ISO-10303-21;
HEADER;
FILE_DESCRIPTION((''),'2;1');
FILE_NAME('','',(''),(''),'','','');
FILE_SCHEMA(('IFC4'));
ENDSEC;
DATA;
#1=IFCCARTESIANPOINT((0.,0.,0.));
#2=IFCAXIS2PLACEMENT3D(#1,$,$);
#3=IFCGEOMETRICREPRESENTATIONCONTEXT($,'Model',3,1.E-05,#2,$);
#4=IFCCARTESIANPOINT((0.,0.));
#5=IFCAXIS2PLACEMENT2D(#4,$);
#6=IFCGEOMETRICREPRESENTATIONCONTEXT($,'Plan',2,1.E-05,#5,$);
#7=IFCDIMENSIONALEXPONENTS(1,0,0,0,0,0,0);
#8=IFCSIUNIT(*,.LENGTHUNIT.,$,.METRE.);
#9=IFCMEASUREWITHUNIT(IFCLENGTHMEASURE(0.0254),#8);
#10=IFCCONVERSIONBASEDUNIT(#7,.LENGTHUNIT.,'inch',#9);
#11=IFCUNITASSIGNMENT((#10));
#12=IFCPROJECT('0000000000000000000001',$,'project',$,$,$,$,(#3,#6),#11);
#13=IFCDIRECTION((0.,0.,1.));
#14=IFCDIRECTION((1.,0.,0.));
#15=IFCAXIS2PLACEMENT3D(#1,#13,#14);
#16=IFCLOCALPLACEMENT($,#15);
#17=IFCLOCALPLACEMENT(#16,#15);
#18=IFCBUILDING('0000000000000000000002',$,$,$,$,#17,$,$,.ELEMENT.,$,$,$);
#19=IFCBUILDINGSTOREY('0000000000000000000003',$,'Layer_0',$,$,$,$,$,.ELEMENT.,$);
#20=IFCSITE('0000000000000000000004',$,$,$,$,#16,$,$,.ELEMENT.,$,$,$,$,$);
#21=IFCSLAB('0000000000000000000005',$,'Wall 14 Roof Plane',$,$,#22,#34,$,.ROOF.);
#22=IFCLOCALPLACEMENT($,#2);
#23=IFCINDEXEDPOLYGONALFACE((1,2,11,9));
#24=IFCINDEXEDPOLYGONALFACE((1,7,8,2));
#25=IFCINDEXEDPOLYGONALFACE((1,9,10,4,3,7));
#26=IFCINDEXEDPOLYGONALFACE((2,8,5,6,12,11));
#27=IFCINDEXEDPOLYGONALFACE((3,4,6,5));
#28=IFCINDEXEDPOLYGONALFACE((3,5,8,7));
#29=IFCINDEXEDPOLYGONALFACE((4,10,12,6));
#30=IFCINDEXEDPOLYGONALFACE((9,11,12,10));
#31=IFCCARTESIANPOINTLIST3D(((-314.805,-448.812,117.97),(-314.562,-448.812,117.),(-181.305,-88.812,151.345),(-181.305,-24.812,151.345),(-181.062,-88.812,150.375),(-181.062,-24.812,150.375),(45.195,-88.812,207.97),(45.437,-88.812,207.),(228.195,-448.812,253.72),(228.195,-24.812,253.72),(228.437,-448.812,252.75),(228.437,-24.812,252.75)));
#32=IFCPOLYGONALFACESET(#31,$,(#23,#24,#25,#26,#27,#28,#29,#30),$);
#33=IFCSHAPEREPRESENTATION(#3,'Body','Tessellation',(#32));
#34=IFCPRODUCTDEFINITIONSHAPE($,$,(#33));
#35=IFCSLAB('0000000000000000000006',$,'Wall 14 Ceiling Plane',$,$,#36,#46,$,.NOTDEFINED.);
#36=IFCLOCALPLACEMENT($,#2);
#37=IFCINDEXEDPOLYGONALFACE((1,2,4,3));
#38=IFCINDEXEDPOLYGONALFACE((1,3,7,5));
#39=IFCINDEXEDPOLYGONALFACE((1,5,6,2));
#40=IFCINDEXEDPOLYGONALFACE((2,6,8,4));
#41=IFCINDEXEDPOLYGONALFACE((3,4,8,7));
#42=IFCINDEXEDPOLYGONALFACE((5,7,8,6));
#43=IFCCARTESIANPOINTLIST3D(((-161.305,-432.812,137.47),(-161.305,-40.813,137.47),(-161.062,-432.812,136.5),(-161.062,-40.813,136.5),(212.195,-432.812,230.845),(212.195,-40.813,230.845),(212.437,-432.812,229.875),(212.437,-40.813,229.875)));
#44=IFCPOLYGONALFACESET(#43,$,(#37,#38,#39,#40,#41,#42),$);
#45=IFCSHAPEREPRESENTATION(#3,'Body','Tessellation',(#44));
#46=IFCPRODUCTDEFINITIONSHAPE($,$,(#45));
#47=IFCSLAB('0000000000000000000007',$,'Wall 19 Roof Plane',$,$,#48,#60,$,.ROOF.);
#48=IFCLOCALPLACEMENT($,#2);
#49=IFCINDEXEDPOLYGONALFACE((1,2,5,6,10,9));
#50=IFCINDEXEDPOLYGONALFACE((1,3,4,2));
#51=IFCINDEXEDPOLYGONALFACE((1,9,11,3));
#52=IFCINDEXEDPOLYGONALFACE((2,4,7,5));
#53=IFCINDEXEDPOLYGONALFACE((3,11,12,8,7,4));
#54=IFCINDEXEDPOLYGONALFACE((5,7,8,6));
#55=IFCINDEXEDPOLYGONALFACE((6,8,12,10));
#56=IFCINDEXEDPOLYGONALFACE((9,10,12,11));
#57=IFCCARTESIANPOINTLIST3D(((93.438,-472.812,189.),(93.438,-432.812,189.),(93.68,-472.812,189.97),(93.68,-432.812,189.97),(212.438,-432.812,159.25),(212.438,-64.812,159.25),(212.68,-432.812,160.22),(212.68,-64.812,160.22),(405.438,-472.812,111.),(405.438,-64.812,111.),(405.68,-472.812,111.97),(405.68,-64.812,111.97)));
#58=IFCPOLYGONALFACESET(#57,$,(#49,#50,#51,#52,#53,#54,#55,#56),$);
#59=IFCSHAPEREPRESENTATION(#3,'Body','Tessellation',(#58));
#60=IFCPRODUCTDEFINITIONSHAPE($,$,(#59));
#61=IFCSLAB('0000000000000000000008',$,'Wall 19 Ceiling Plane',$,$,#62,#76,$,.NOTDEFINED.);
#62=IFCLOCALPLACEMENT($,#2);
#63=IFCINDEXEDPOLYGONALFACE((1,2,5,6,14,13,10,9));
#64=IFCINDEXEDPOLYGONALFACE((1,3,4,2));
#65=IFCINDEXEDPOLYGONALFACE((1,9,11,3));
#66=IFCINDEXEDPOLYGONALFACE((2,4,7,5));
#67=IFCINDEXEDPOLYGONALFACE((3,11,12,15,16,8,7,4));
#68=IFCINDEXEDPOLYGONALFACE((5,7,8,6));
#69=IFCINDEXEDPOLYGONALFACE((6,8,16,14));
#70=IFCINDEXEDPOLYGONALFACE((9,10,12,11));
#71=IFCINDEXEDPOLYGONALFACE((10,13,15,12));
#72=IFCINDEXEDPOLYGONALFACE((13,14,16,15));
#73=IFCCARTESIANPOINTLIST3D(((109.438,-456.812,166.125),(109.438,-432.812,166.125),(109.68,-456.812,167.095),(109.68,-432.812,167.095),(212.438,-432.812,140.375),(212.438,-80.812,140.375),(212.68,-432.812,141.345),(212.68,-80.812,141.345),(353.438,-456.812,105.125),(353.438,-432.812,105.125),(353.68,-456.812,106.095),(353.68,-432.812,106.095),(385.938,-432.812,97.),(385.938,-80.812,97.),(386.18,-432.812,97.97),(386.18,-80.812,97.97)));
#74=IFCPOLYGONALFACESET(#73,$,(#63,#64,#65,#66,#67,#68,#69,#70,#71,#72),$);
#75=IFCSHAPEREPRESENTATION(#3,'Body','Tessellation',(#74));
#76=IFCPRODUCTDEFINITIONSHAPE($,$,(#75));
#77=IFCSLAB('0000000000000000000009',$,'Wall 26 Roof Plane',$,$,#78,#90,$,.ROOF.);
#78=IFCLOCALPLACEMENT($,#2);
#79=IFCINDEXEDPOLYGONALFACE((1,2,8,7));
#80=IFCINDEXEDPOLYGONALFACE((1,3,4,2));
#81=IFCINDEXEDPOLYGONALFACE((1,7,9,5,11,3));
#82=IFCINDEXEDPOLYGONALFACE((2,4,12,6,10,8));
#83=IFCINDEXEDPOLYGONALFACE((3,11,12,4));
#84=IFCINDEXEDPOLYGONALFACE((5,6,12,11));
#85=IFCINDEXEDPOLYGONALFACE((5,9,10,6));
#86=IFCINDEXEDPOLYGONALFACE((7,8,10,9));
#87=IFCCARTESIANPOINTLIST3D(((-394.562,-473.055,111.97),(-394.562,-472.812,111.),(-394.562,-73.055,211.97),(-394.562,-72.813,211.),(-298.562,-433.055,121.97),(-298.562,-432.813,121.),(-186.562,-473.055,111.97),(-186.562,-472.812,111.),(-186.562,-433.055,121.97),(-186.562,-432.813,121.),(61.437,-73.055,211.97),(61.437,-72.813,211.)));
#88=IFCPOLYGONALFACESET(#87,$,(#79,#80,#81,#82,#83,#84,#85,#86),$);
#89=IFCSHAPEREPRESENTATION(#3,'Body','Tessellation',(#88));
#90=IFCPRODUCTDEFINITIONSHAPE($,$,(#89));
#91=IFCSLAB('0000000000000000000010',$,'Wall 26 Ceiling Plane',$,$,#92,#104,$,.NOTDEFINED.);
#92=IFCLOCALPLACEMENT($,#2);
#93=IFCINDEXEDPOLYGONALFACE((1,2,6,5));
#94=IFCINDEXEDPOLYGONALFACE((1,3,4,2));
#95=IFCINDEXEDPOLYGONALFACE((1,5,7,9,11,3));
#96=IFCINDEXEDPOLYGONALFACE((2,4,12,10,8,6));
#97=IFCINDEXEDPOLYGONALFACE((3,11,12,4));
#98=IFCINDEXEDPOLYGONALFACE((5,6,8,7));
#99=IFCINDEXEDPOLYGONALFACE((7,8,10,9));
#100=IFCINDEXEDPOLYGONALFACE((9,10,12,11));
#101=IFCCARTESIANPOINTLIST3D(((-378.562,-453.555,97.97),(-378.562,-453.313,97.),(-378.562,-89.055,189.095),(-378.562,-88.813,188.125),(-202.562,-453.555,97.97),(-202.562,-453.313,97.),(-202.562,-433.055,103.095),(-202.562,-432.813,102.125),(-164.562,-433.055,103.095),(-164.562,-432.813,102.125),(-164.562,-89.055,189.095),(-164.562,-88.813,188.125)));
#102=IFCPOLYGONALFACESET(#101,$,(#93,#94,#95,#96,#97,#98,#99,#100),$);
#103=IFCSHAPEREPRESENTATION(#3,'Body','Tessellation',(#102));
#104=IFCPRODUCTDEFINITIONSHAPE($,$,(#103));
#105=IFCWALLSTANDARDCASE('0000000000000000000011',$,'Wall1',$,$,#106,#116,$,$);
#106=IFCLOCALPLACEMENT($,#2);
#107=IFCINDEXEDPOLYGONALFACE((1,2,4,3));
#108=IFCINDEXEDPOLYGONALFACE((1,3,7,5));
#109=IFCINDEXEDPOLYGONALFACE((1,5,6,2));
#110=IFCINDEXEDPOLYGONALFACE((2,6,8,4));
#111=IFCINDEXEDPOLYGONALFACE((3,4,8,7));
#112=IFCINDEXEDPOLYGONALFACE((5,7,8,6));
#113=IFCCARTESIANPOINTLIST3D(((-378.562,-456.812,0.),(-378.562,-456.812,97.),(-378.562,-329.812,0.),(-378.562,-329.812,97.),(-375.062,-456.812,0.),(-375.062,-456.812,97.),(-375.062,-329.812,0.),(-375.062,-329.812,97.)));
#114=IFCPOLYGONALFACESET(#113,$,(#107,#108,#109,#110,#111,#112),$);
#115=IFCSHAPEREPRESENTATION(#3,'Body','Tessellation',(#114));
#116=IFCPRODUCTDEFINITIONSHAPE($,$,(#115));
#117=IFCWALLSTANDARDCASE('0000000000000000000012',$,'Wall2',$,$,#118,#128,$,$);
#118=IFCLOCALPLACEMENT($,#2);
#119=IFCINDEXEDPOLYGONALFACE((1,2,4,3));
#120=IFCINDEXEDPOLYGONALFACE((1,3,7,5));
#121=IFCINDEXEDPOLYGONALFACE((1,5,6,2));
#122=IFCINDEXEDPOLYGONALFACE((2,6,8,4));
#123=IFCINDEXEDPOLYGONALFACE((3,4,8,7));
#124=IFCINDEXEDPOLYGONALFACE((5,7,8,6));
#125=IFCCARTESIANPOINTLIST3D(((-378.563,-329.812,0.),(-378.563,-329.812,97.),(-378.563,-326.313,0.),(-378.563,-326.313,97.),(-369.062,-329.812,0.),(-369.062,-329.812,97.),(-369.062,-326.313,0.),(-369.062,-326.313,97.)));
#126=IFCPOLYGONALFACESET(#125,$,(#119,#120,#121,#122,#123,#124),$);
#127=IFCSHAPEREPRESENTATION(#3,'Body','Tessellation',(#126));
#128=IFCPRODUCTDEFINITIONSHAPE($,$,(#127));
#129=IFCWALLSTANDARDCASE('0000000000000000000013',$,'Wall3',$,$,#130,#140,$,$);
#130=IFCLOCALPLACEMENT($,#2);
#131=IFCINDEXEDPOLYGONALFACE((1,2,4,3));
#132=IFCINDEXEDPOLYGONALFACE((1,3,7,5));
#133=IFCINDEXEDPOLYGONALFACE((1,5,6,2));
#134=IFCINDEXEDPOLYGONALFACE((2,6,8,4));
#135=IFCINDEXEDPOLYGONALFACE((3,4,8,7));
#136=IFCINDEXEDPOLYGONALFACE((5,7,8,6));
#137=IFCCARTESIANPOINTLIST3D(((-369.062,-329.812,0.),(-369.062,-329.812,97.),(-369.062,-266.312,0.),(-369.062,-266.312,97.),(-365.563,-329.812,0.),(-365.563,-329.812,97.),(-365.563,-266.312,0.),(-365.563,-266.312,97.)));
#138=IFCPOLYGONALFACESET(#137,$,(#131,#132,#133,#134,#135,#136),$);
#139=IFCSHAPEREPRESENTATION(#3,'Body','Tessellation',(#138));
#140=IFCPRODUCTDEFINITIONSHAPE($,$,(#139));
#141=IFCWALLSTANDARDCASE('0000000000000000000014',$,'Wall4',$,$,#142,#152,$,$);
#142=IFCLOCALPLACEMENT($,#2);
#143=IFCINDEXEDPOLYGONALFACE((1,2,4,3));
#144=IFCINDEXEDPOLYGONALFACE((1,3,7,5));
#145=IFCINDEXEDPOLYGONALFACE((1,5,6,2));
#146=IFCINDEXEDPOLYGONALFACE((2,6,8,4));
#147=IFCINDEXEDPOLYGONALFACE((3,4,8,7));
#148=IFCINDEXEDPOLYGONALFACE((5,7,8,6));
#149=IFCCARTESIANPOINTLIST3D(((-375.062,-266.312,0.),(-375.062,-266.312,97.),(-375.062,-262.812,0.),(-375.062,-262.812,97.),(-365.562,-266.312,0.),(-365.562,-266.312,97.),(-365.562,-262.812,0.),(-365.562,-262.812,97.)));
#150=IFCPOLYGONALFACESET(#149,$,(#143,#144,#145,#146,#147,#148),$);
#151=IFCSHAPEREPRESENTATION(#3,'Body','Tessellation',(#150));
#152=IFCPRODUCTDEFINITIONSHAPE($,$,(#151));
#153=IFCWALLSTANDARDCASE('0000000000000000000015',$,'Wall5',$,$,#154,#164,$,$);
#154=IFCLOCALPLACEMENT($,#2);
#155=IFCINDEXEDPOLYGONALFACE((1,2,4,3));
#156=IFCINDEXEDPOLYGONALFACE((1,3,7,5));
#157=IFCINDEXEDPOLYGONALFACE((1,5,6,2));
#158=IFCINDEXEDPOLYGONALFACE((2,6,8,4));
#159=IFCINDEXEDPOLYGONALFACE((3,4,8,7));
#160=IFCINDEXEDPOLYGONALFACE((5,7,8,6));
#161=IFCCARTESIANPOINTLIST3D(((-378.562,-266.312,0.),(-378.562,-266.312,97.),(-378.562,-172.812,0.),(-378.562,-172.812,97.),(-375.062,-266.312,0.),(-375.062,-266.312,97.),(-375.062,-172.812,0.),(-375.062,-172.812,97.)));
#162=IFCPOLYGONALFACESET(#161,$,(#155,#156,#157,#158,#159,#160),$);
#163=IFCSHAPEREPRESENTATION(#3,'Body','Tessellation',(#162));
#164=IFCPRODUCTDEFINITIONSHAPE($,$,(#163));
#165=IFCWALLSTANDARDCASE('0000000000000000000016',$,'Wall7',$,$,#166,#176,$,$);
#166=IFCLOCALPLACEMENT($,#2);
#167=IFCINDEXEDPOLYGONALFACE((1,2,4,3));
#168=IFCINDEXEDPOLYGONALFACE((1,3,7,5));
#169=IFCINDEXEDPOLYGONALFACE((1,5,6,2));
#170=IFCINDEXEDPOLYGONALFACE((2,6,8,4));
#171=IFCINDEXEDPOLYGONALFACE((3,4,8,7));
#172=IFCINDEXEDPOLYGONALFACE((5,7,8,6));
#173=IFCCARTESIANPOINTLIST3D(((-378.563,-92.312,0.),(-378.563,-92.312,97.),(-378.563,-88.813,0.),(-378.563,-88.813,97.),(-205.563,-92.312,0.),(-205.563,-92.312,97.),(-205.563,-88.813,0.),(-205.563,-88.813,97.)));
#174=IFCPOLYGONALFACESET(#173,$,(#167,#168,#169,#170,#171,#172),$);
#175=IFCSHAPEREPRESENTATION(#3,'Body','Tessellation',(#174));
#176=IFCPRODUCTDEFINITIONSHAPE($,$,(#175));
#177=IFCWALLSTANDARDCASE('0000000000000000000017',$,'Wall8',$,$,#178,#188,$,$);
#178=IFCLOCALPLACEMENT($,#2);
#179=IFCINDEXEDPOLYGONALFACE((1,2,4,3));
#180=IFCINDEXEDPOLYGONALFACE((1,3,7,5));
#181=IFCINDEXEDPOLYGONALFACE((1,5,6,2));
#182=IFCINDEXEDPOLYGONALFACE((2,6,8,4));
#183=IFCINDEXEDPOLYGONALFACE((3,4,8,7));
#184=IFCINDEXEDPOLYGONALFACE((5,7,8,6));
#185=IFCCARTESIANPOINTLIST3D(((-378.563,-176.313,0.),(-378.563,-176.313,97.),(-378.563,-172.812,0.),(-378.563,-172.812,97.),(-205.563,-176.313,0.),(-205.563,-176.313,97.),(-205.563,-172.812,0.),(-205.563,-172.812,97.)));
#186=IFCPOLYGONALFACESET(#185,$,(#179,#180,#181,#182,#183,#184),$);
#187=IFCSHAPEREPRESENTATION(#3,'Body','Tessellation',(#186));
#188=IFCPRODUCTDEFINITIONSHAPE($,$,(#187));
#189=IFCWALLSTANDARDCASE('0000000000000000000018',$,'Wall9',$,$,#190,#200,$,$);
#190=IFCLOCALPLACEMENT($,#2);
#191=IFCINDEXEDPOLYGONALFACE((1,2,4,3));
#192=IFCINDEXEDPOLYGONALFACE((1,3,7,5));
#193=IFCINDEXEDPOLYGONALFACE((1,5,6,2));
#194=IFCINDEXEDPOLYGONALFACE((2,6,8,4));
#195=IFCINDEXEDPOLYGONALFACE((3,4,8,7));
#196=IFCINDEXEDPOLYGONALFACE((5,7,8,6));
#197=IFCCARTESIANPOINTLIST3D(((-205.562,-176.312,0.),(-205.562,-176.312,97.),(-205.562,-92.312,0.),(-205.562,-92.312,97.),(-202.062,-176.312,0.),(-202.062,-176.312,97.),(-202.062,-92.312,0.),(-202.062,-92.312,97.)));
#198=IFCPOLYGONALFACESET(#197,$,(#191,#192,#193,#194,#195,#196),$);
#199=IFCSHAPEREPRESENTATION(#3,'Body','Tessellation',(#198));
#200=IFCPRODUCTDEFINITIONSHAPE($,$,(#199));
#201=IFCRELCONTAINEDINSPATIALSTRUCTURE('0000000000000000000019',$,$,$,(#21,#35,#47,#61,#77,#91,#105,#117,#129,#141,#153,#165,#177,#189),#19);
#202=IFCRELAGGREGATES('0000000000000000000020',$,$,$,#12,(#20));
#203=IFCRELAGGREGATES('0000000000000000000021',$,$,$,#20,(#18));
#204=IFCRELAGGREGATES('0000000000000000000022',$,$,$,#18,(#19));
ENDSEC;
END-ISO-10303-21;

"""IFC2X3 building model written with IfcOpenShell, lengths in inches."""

from ifc_helpers import new_model, entity, si_unit, converted_unit, frame, origin, origin_with_axes, origin_2d, place, context, project, spatial, polyline, outline, extrude, element, save


model = new_model("IFC2X3")

# Units and contexts
model_context = context("Model", 3, precision=1e-05, world=origin())
plan_context = context("Plan", 2, precision=1e-05, world=origin_2d())
ifc_project = project(units=[converted_unit("LENGTHUNIT", "inch", entity("IfcLengthMeasure", 0.0254), si_unit("LENGTHUNIT", "METRE"), dimensions=[1, 0, 0, 0, 0, 0, 0])], contexts=[model_context, plan_context])

# Site, building, storey
site_placement = place(None, origin_with_axes())
site = spatial("IfcSite", under=ifc_project, at=site_placement, CompositionType="ELEMENT")
building_placement = place(site_placement, origin_with_axes())
building = spatial("IfcBuilding", under=site, at=building_placement, CompositionType="ELEMENT")
storey = spatial("IfcBuildingStorey", under=building, Name="Layer_0", CompositionType="ELEMENT")

# Slabs
placement = place(building_placement, origin_with_axes())
slab_1_placement = place(placement, frame((-181.062, -88.812, 150.375), z_axis=(-0.242536, 0.0, 0.970143), x_axis=(0.0, 1.0, 0.0)))
element("IfcSlab", 1, at=slab_1_placement, inside=storey, Name="Wall 14 Roof Plane", PredefinedType="ROOF", context=model_context, shape_type="SweptSolid", body=[
    extrude(outline(polyline([(0.0, 0.0), (64.0, 0.0), (64.0, -422.103), (-360.0, -422.103), (-360.0, 137.609), (0.0, -233.471), (0.0, 0.0)])), origin(), (0.0, 0.0, 1.0), 1.0),
])
slab_2_placement = place(placement, frame((-161.062, -432.812, 136.5), z_axis=(-0.242536, 0.0, 0.970143), x_axis=(0.0, 1.0, 0.0)))
element("IfcSlab", 2, at=slab_2_placement, inside=storey, Name="Wall 14 Ceiling Plane", PredefinedType="NOTDEFINED", context=model_context, shape_type="SweptSolid", body=[
    extrude(outline(polyline([(0.0, 0.0), (392.0, 0.0), (392.0, -384.995), (0.0, -384.995), (0.0, 0.0)])), origin(), (0.0, 0.0, 1.0), 1.0),
])
slab_3_placement = place(placement, frame((405.438, -64.812, 111.0), z_axis=(0.242536, 0.0, 0.970143), x_axis=(0.0, -1.0, 0.0)))
element("IfcSlab", 3, at=slab_3_placement, inside=storey, Name="Wall 19 Roof Plane", PredefinedType="ROOF", context=model_context, shape_type="SweptSolid", body=[
    extrude(outline(polyline([(0.0, 0.0), (408.0, 0.0), (408.0, -321.602), (368.0, -321.602), (368.0, -198.94), (0.0, -198.94), (0.0, 0.0)])), origin(), (0.0, 0.0, 1.0), 1.0),
])
slab_4_placement = place(placement, frame((385.938, -80.812, 97.0), z_axis=(0.242536, 0.0, 0.970143), x_axis=(0.0, -1.0, 0.0)))
element("IfcSlab", 4, at=slab_4_placement, inside=storey, Name="Wall 19 Ceiling Plane", PredefinedType="NOTDEFINED", context=model_context, shape_type="SweptSolid", body=[
    extrude(outline(polyline([(0.0, 0.0), (352.0, 0.0), (352.0, -33.5), (376.0, -33.5), (376.0, -285.01), (352.0, -285.01), (352.0, -178.84), (0.0, -178.84), (0.0, 0.0)])), origin(), (0.0, 0.0, 1.0), 1.0),
])
slab_5_placement = place(placement, frame((-186.562, -472.812, 111.0), z_axis=(0.0, -0.242536, 0.970143), x_axis=(-1.0, 0.0, 0.0)))
element("IfcSlab", 5, at=slab_5_placement, inside=storey, Name="Wall 26 Roof Plane", PredefinedType="ROOF", context=model_context, shape_type="SweptSolid", body=[
    extrude(outline(polyline([(0.0, 0.0), (208.0, 0.0), (208.0, -412.311), (-248.0, -412.311), (112.0, -41.231), (0.0, -41.231), (0.0, 0.0)])), origin(), (0.0, 0.0, 1.0), 1.0),
])
slab_6_placement = place(placement, frame((-202.562, -453.312, 97.0), z_axis=(0.0, -0.242536, 0.970143), x_axis=(-1.0, 0.0, 0.0)))
element("IfcSlab", 6, at=slab_6_placement, inside=storey, Name="Wall 26 Ceiling Plane", PredefinedType="NOTDEFINED", context=model_context, shape_type="SweptSolid", body=[
    extrude(outline(polyline([(0.0, 0.0), (176.0, 0.0), (176.0, -375.718), (-38.0, -375.718), (-38.0, -21.131), (0.0, -21.131), (0.0, 0.0)])), origin(), (0.0, 0.0, 1.0), 1.0),
])

# Walls
wall_1_placement = place(placement, frame((-376.812, -456.812, 0.0), z_axis=(0.0, 0.0, 1.0), x_axis=(0.0, 1.0, 0.0)))
element("IfcWallStandardCase", 7, at=wall_1_placement, inside=storey, Name="Wall1", context=model_context, shape_type="SweptSolid", body=[
    extrude(outline(polyline([(0.0, -1.75), (0.0, 1.75), (127.0, 1.75), (127.0, -1.75), (0.0, -1.75)])), origin(), (0.0, 0.0, 1.0), 97.0),
])
wall_2_placement = place(placement, frame((-378.562, -328.062, 0.0), z_axis=(0.0, 0.0, 1.0), x_axis=(1.0, 0.0, 0.0)))
element("IfcWallStandardCase", 8, at=wall_2_placement, inside=storey, Name="Wall2", context=model_context, shape_type="SweptSolid", body=[
    extrude(outline(polyline([(0.0, -1.75), (0.0, 1.75), (9.5, 1.75), (9.5, -1.75), (0.0, -1.75)])), origin(), (0.0, 0.0, 1.0), 97.0),
])
wall_3_placement = place(placement, frame((-367.312, -329.812, 0.0), z_axis=(0.0, 0.0, 1.0), x_axis=(0.0, 1.0, 0.0)))
element("IfcWallStandardCase", 9, at=wall_3_placement, inside=storey, Name="Wall3", context=model_context, shape_type="SweptSolid", body=[
    extrude(outline(polyline([(0.0, -1.75), (0.0, 1.75), (63.5, 1.75), (63.5, -1.75), (0.0, -1.75)])), origin(), (0.0, 0.0, 1.0), 97.0),
])
wall_4_placement = place(placement, frame((-365.562, -264.562, 0.0), z_axis=(0.0, 0.0, 1.0), x_axis=(-1.0, 0.0, 0.0)))
element("IfcWallStandardCase", 10, at=wall_4_placement, inside=storey, Name="Wall4", context=model_context, shape_type="SweptSolid", body=[
    extrude(outline(polyline([(0.0, -1.75), (0.0, 1.75), (9.5, 1.75), (9.5, -1.75), (0.0, -1.75)])), origin(), (0.0, 0.0, 1.0), 97.0),
])
wall_5_placement = place(placement, frame((-376.812, -266.312, 0.0), z_axis=(0.0, 0.0, 1.0), x_axis=(0.0, 1.0, 0.0)))
element("IfcWallStandardCase", 11, at=wall_5_placement, inside=storey, Name="Wall5", context=model_context, shape_type="SweptSolid", body=[
    extrude(outline(polyline([(0.0, -1.75), (0.0, 1.75), (93.5, 1.75), (93.5, -1.75), (0.0, -1.75)])), origin(), (0.0, 0.0, 1.0), 97.0),
])
for number, where, z_axis, x_axis, name in (
    (12, (-378.562, -90.562, 0.0), (0.0, 0.0, 1.0), (1.0, 0.0, 0.0), "Wall7"),
    (13, (-378.562, -174.562, 0.0), (0.0, 0.0, 1.0), (1.0, 0.0, 0.0), "Wall8"),
):
    element("IfcWallStandardCase", number, at=place(placement, frame(where, z_axis=z_axis, x_axis=x_axis)), inside=storey, Name=name, context=model_context, shape_type="SweptSolid", body=[
        extrude(outline(polyline([(0.0, -1.75), (0.0, 1.75), (173.0, 1.75), (173.0, -1.75), (0.0, -1.75)])), origin(), (0.0, 0.0, 1.0), 97.0),
    ])
wall_6_placement = place(placement, frame((-203.812, -176.312, 0.0), z_axis=(0.0, 0.0, 1.0), x_axis=(0.0, 1.0, 0.0)))
element("IfcWallStandardCase", 14, at=wall_6_placement, inside=storey, Name="Wall9", context=model_context, shape_type="SweptSolid", body=[
    extrude(outline(polyline([(0.0, -1.75), (0.0, 1.75), (84.0, 1.75), (84.0, -1.75), (0.0, -1.75)])), origin(), (0.0, 0.0, 1.0), 97.0),
])

save(model, "model.ifc")
